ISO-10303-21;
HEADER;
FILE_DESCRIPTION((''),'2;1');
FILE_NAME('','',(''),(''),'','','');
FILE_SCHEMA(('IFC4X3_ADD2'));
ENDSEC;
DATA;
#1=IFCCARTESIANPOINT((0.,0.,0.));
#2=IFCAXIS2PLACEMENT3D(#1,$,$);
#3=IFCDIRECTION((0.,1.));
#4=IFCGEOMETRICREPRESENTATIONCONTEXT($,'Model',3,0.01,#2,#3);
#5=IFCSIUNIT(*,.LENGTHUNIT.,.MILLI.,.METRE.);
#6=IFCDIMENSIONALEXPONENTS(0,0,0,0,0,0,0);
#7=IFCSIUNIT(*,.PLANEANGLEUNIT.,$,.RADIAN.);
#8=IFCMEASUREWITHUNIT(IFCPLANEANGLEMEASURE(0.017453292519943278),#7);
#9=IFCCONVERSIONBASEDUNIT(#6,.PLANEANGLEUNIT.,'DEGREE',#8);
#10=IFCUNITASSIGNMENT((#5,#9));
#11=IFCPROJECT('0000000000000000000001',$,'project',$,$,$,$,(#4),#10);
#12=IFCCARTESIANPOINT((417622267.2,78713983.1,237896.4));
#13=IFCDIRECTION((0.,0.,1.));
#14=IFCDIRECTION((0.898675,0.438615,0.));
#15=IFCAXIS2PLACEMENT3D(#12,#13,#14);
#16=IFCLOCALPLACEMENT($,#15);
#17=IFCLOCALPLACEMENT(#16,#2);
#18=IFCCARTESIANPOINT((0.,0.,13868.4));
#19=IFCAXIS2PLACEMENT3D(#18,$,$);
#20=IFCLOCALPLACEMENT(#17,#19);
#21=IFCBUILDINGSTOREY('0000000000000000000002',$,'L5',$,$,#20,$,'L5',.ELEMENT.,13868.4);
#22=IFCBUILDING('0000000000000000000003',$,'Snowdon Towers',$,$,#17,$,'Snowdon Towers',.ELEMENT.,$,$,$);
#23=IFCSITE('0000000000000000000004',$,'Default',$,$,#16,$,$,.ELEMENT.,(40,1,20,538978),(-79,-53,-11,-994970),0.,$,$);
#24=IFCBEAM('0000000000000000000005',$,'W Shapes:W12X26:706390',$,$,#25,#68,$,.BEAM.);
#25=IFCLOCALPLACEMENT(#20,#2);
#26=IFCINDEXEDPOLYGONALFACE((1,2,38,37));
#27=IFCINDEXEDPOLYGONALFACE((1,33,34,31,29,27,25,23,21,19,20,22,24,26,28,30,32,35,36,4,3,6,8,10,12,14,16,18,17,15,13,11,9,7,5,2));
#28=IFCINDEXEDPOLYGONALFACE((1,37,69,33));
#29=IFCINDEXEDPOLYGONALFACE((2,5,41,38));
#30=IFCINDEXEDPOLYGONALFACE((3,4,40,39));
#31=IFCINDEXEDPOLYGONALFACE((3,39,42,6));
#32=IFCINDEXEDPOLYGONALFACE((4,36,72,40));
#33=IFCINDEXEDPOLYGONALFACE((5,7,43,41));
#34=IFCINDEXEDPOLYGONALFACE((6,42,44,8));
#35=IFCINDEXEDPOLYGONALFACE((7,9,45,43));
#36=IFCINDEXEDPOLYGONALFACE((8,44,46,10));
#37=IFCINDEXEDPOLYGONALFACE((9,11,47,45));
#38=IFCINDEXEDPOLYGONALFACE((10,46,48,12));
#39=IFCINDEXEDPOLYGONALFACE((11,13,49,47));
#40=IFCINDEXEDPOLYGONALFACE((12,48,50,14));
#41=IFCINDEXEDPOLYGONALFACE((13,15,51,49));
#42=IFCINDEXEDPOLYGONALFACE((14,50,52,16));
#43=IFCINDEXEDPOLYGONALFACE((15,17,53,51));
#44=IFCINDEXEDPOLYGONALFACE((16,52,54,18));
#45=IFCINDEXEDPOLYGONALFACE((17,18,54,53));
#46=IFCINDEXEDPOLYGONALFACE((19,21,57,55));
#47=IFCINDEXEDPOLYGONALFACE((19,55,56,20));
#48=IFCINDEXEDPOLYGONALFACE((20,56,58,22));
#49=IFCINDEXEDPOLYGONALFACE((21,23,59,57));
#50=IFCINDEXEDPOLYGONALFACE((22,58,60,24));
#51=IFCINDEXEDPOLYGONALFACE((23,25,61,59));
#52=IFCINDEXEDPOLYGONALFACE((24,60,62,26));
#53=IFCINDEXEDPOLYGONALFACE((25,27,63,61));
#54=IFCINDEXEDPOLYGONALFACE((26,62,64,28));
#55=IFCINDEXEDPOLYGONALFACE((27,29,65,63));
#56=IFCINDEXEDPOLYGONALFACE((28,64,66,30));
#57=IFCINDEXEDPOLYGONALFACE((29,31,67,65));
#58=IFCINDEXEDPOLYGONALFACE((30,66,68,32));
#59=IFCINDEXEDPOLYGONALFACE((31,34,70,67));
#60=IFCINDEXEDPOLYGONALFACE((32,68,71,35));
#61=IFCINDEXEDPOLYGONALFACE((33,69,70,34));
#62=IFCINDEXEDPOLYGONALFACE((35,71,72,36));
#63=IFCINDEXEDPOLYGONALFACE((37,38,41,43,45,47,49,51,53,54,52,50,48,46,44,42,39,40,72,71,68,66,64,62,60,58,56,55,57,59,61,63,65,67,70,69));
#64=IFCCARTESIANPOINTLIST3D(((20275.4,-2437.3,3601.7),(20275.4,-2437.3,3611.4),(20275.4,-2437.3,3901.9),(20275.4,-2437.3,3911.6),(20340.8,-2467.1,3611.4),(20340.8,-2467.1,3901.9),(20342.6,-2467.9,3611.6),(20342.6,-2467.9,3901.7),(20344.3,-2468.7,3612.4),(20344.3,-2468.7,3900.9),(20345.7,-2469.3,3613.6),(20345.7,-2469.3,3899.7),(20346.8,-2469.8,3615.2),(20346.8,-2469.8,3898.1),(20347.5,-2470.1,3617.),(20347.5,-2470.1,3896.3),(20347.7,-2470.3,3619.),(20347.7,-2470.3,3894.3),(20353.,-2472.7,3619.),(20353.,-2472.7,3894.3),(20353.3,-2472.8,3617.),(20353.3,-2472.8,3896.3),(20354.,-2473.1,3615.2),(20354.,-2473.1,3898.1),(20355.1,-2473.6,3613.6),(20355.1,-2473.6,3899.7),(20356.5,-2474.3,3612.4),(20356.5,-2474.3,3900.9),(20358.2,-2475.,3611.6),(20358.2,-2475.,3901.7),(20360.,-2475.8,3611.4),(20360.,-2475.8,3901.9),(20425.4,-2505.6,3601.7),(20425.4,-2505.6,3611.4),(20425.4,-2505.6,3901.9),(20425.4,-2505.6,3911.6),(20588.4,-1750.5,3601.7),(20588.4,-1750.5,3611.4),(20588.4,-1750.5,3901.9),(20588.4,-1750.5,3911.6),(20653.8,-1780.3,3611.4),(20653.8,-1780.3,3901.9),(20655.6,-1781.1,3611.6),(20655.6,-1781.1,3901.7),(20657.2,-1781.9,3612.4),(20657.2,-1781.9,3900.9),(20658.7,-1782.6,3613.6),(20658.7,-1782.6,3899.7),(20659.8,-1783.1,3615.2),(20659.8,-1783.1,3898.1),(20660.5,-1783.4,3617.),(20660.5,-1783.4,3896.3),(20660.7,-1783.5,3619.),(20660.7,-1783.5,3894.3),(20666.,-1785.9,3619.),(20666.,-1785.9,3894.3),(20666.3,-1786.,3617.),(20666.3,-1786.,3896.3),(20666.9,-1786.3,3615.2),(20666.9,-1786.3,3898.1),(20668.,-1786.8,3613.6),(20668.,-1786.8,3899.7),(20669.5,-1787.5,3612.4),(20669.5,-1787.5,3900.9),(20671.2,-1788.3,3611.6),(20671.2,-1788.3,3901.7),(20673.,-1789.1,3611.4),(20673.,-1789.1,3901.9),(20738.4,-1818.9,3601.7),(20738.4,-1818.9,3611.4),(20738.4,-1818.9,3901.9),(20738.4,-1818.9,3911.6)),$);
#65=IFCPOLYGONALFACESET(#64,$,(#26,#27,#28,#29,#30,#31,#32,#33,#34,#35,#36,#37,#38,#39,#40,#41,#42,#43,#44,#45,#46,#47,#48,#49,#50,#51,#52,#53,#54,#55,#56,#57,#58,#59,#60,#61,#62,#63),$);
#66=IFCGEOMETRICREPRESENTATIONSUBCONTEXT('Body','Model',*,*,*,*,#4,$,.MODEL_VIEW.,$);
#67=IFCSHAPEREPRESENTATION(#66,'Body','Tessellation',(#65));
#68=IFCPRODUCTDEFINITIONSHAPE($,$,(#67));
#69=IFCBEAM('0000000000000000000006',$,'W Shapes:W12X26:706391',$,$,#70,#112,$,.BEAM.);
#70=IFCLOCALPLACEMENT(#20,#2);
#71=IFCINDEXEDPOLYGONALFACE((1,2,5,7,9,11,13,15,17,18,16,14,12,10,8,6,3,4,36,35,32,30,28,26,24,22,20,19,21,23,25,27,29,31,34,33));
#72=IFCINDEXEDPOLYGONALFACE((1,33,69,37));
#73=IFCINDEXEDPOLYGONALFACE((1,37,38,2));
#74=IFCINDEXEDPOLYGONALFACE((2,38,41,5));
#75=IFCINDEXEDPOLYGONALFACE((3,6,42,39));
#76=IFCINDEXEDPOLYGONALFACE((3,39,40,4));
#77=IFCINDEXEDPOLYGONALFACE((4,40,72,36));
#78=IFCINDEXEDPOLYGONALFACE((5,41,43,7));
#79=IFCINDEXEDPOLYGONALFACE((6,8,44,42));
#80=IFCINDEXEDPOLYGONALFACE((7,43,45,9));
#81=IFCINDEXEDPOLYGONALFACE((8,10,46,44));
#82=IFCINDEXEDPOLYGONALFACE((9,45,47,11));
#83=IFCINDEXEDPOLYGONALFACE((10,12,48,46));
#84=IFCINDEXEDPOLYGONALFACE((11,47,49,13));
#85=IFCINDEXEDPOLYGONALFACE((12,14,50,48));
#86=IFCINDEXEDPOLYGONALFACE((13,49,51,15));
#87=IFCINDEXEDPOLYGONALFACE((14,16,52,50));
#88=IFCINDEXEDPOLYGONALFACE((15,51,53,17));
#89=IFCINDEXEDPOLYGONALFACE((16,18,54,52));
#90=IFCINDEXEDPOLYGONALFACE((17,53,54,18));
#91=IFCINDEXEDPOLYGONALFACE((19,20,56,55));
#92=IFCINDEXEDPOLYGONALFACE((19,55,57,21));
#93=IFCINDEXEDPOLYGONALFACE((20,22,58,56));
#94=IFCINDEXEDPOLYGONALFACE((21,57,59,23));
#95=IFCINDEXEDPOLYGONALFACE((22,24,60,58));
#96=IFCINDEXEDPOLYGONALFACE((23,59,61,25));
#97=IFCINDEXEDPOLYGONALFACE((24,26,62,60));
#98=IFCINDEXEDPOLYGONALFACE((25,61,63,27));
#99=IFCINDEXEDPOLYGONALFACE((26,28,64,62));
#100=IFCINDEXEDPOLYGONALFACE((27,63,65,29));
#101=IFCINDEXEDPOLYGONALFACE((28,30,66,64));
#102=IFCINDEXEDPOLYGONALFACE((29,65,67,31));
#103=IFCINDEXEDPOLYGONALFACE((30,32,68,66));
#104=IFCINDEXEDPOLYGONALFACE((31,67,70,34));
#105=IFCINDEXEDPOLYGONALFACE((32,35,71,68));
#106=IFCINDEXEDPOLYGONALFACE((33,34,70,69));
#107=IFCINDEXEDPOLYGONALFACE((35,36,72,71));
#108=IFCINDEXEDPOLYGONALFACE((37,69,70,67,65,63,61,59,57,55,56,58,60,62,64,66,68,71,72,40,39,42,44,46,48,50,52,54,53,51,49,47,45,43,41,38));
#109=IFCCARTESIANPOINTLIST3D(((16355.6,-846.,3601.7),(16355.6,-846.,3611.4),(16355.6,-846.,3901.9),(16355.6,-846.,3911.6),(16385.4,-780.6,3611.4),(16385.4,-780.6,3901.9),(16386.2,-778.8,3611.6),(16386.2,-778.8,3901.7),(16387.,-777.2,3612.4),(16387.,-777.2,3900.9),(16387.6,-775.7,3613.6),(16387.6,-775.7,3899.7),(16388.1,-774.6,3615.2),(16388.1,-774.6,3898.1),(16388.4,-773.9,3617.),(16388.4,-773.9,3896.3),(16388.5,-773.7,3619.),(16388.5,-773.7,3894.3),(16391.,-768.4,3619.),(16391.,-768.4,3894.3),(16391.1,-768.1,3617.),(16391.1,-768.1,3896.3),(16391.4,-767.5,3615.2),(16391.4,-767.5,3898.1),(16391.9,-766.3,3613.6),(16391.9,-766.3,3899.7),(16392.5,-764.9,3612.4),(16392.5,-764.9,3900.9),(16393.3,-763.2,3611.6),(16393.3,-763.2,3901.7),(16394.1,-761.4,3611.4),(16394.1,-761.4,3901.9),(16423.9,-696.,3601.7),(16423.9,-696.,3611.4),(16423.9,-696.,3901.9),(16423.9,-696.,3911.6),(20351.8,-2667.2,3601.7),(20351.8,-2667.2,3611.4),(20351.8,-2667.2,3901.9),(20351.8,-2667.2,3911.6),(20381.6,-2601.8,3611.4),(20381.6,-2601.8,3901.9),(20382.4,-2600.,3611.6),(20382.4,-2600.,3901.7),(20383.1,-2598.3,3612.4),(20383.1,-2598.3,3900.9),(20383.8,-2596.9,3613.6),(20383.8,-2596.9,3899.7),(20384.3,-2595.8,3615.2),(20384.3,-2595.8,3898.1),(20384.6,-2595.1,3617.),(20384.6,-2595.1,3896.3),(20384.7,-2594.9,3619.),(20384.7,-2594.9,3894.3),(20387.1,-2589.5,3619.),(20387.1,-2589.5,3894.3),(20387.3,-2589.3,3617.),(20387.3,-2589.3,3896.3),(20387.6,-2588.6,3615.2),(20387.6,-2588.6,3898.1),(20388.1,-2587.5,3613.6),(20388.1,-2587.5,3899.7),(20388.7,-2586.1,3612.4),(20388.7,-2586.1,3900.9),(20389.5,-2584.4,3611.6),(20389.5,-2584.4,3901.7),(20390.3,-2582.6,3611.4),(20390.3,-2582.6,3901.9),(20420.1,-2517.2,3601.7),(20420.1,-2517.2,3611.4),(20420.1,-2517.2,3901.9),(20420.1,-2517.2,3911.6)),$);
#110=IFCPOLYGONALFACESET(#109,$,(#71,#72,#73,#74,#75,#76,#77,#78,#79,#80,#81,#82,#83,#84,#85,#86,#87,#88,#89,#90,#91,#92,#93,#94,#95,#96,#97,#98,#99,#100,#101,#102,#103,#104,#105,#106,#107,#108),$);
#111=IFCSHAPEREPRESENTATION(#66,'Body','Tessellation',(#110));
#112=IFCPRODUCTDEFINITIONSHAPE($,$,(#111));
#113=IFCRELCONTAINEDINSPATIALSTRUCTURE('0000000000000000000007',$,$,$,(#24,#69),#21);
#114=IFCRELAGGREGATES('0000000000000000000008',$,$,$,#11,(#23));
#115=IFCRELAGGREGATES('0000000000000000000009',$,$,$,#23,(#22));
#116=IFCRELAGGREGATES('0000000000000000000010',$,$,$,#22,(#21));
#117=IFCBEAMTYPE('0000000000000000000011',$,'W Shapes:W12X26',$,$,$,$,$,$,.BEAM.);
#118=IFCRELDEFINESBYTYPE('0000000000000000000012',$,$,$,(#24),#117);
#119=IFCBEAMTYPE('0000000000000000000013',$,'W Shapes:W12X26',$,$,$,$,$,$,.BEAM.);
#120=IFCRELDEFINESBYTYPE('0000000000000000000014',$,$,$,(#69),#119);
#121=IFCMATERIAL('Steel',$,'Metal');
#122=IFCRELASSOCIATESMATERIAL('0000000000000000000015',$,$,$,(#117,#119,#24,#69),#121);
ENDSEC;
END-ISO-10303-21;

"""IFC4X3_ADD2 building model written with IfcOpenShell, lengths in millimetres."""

from ifc_helpers import new_model, entity, si_unit, converted_unit, direction, frame, frame_2d, origin, place, context, subcontext, project, spatial, polyline, circle_curve, parameter, trimmed, segment, composite_curve, outline, extrude, source, transform, mapped, material, material_profile, profile_set, profile_usage, type_object, type_shapes, element, save


model = new_model("IFC4X3_ADD2")

# Units and contexts
model_context = context("Model", 3, precision=0.01, world=origin(), true_north=direction((0.0, 1.0)))
body_context = subcontext(model_context, "Body", "Model", "MODEL_VIEW")
ifc_project = project(units=[si_unit("LENGTHUNIT", "METRE", prefix="MILLI"), converted_unit("PLANEANGLEUNIT", "DEGREE", entity("IfcPlaneAngleMeasure", 0.017453292519943278), si_unit("PLANEANGLEUNIT", "RADIAN"), dimensions=[0, 0, 0, 0, 0, 0, 0])], contexts=[model_context])

# Site, building, storey
site_placement = place(None, frame((417622267.2, 78713983.1, 237896.4), z_axis=(0.0, 0.0, 1.0), x_axis=(0.898675, 0.438615, 0.0)))
site = spatial("IfcSite", under=ifc_project, at=site_placement, Name="Default", CompositionType="ELEMENT", RefLatitude=(40, 1, 20, 538978), RefLongitude=(-79, -53, -11, -994970), RefElevation=0.0)
building_placement = place(site_placement, origin())
building = spatial("IfcBuilding", under=site, at=building_placement, Name="Snowdon Towers", LongName="Snowdon Towers", CompositionType="ELEMENT")
storey_placement = place(building_placement, frame((0.0, 0.0, 13868.4)))
storey = spatial("IfcBuildingStorey", under=building, at=storey_placement, Name="L5", LongName="L5", CompositionType="ELEMENT", Elevation=13868.4)

# Shared definitions
ifc_material_1 = material(Name="Steel", Category="Metal")

# Beams
ifc_material_profile_1 = material_profile(ifc_material_1, outline(composite_curve([segment(polyline([(-82.4, -145.3), (-82.4, -154.9)]), True, "CONTINUOUS"), segment(polyline([(-82.4, -154.9), (82.4, -154.9)]), True, "CONTINUOUS"), segment(polyline([(82.4, -154.9), (82.4, -145.3)]), True, "CONTINUOUS"), segment(polyline([(82.4, -145.3), (10.5, -145.3)]), True, "CONTINUOUS"), segment(trimmed(circle_curve(frame_2d((10.5, -137.7), x_axis=(1.0, 0.0)), 7.6), [parameter(180.0)], [parameter(270.0)], True, "PARAMETER"), False, "CONTINUOUS"), segment(polyline([(2.9, -137.7), (2.9, 137.7)]), True, "CONTINUOUS"), segment(trimmed(circle_curve(frame_2d((10.5, 137.7), x_axis=(1.0, 0.0)), 7.6), [parameter(90.0)], [parameter(180.0)], True, "PARAMETER"), False, "CONTINUOUS"), segment(polyline([(10.5, 145.3), (82.4, 145.3)]), True, "CONTINUOUS"), segment(polyline([(82.4, 145.3), (82.4, 154.9)]), True, "CONTINUOUS"), segment(polyline([(82.4, 154.9), (-82.4, 154.9)]), True, "CONTINUOUS"), segment(polyline([(-82.4, 154.9), (-82.4, 145.3)]), True, "CONTINUOUS"), segment(polyline([(-82.4, 145.3), (-10.5, 145.3)]), True, "CONTINUOUS"), segment(trimmed(circle_curve(frame_2d((-10.5, 137.7), x_axis=(1.0, 0.0)), 7.6), [parameter(360.0)], [parameter(90.0)], True, "PARAMETER"), False, "CONTINUOUS"), segment(polyline([(-2.9, 137.7), (-2.9, -137.7)]), True, "CONTINUOUS"), segment(trimmed(circle_curve(frame_2d((-10.5, -137.7), x_axis=(1.0, 0.0)), 7.6), [parameter(270.0)], [parameter(360.0)], True, "PARAMETER"), False, "CONTINUOUS"), segment(polyline([(-10.5, -145.3), (-82.4, -145.3)]), True, "CONTINUOUS")], self_intersect=False)), Name="W12X26")
ifc_profile_set_1 = profile_set([ifc_material_profile_1], Name="W12X26")
ifc_profile_usage_1 = profile_usage(ifc_profile_set_1, cardinal=8)
beam_type_1 = type_object("IfcBeamType", Name="W Shapes:W12X26", PredefinedType="BEAM", material=ifc_profile_set_1)
shared_shape_1 = source(origin(), body_context, "Body", "SweptSolid", [
    extrude(outline(composite_curve([segment(polyline([(-82.4, -145.3), (-82.4, -154.9)]), True, "CONTINUOUS"), segment(polyline([(-82.4, -154.9), (82.4, -154.9)]), True, "CONTINUOUS"), segment(polyline([(82.4, -154.9), (82.4, -145.3)]), True, "CONTINUOUS"), segment(polyline([(82.4, -145.3), (10.5, -145.3)]), True, "CONTINUOUS"), segment(trimmed(circle_curve(frame_2d((10.5, -137.7), x_axis=(1.0, 0.0)), 7.6), [parameter(180.0)], [parameter(270.0)], True, "PARAMETER"), False, "CONTINUOUS"), segment(polyline([(2.9, -137.7), (2.9, 137.7)]), True, "CONTINUOUS"), segment(trimmed(circle_curve(frame_2d((10.5, 137.7), x_axis=(1.0, 0.0)), 7.6), [parameter(90.0)], [parameter(180.0)], True, "PARAMETER"), False, "CONTINUOUS"), segment(polyline([(10.5, 145.3), (82.4, 145.3)]), True, "CONTINUOUS"), segment(polyline([(82.4, 145.3), (82.4, 154.9)]), True, "CONTINUOUS"), segment(polyline([(82.4, 154.9), (-82.4, 154.9)]), True, "CONTINUOUS"), segment(polyline([(-82.4, 154.9), (-82.4, 145.3)]), True, "CONTINUOUS"), segment(polyline([(-82.4, 145.3), (-10.5, 145.3)]), True, "CONTINUOUS"), segment(trimmed(circle_curve(frame_2d((-10.5, 137.7), x_axis=(1.0, 0.0)), 7.6), [parameter(360.0)], [parameter(90.0)], True, "PARAMETER"), False, "CONTINUOUS"), segment(polyline([(-2.9, 137.7), (-2.9, -137.7)]), True, "CONTINUOUS"), segment(trimmed(circle_curve(frame_2d((-10.5, -137.7), x_axis=(1.0, 0.0)), 7.6), [parameter(270.0)], [parameter(360.0)], True, "PARAMETER"), False, "CONTINUOUS"), segment(polyline([(-10.5, -145.3), (-82.4, -145.3)]), True, "CONTINUOUS")], self_intersect=False)), frame((-406.1, 0.0, 0.0), z_axis=(-1.0, 0.0, 0.0), x_axis=(0.0, -1.0, 0.0)), (0.0, 0.0, -1.0), 754.7),
])
type_shapes(beam_type_1, [shared_shape_1])
beam_1_placement = place(storey_placement, frame((20518.8, -2101.9, 3756.7), z_axis=(0.0, 0.0, 1.0), x_axis=(0.414693, 0.909961, 0.0)))
element("IfcBeam", 1, at=beam_1_placement, inside=storey, type_object=beam_type_1, material=ifc_profile_usage_1, Name="W Shapes:W12X26:706390", PredefinedType="BEAM", context=body_context, shape_type="MappedRepresentation", body=[
    mapped(shared_shape_1, transform((0.0, 0.0, 0.0), scale=1.0)),
])
beam_type_2 = type_object("IfcBeamType", Name="W Shapes:W12X26", PredefinedType="BEAM", material=ifc_profile_set_1)
shared_shape_2 = source(origin(), body_context, "Body", "SweptSolid", [
    extrude(outline(composite_curve([segment(polyline([(-82.4, -145.3), (-82.4, -154.9)]), True, "CONTINUOUS"), segment(polyline([(-82.4, -154.9), (82.4, -154.9)]), True, "CONTINUOUS"), segment(polyline([(82.4, -154.9), (82.4, -145.3)]), True, "CONTINUOUS"), segment(polyline([(82.4, -145.3), (10.5, -145.3)]), True, "CONTINUOUS"), segment(trimmed(circle_curve(frame_2d((10.5, -137.7), x_axis=(1.0, 0.0)), 7.6), [parameter(180.0)], [parameter(270.0)], True, "PARAMETER"), False, "CONTINUOUS"), segment(polyline([(2.9, -137.7), (2.9, 137.7)]), True, "CONTINUOUS"), segment(trimmed(circle_curve(frame_2d((10.5, 137.7), x_axis=(1.0, 0.0)), 7.6), [parameter(90.0)], [parameter(180.0)], True, "PARAMETER"), False, "CONTINUOUS"), segment(polyline([(10.5, 145.3), (82.4, 145.3)]), True, "CONTINUOUS"), segment(polyline([(82.4, 145.3), (82.4, 154.9)]), True, "CONTINUOUS"), segment(polyline([(82.4, 154.9), (-82.4, 154.9)]), True, "CONTINUOUS"), segment(polyline([(-82.4, 154.9), (-82.4, 145.3)]), True, "CONTINUOUS"), segment(polyline([(-82.4, 145.3), (-10.5, 145.3)]), True, "CONTINUOUS"), segment(trimmed(circle_curve(frame_2d((-10.5, 137.7), x_axis=(1.0, 0.0)), 7.6), [parameter(360.0)], [parameter(90.0)], True, "PARAMETER"), False, "CONTINUOUS"), segment(polyline([(-2.9, 137.7), (-2.9, -137.7)]), True, "CONTINUOUS"), segment(trimmed(circle_curve(frame_2d((-10.5, -137.7), x_axis=(1.0, 0.0)), 7.6), [parameter(270.0)], [parameter(360.0)], True, "PARAMETER"), False, "CONTINUOUS"), segment(polyline([(-10.5, -145.3), (-82.4, -145.3)]), True, "CONTINUOUS")], self_intersect=False)), frame((-2154.6, 0.0, 0.0), z_axis=(-1.0, 0.0, 0.0), x_axis=(0.0, -1.0, 0.0)), (0.0, 0.0, -1.0), 4391.6),
])
type_shapes(beam_type_2, [shared_shape_2])
beam_2_placement = place(storey_placement, frame((18350.3, -1664.5, 3756.7), z_axis=(0.0, 0.0, 1.0), x_axis=(0.909961, -0.414693, 0.0)))
element("IfcBeam", 2, at=beam_2_placement, inside=storey, type_object=beam_type_2, material=ifc_profile_usage_1, Name="W Shapes:W12X26:706391", PredefinedType="BEAM", context=body_context, shape_type="MappedRepresentation", body=[
    mapped(shared_shape_2, transform((0.0, 0.0, 0.0), scale=1.0)),
])

save(model, "model.ifc")
